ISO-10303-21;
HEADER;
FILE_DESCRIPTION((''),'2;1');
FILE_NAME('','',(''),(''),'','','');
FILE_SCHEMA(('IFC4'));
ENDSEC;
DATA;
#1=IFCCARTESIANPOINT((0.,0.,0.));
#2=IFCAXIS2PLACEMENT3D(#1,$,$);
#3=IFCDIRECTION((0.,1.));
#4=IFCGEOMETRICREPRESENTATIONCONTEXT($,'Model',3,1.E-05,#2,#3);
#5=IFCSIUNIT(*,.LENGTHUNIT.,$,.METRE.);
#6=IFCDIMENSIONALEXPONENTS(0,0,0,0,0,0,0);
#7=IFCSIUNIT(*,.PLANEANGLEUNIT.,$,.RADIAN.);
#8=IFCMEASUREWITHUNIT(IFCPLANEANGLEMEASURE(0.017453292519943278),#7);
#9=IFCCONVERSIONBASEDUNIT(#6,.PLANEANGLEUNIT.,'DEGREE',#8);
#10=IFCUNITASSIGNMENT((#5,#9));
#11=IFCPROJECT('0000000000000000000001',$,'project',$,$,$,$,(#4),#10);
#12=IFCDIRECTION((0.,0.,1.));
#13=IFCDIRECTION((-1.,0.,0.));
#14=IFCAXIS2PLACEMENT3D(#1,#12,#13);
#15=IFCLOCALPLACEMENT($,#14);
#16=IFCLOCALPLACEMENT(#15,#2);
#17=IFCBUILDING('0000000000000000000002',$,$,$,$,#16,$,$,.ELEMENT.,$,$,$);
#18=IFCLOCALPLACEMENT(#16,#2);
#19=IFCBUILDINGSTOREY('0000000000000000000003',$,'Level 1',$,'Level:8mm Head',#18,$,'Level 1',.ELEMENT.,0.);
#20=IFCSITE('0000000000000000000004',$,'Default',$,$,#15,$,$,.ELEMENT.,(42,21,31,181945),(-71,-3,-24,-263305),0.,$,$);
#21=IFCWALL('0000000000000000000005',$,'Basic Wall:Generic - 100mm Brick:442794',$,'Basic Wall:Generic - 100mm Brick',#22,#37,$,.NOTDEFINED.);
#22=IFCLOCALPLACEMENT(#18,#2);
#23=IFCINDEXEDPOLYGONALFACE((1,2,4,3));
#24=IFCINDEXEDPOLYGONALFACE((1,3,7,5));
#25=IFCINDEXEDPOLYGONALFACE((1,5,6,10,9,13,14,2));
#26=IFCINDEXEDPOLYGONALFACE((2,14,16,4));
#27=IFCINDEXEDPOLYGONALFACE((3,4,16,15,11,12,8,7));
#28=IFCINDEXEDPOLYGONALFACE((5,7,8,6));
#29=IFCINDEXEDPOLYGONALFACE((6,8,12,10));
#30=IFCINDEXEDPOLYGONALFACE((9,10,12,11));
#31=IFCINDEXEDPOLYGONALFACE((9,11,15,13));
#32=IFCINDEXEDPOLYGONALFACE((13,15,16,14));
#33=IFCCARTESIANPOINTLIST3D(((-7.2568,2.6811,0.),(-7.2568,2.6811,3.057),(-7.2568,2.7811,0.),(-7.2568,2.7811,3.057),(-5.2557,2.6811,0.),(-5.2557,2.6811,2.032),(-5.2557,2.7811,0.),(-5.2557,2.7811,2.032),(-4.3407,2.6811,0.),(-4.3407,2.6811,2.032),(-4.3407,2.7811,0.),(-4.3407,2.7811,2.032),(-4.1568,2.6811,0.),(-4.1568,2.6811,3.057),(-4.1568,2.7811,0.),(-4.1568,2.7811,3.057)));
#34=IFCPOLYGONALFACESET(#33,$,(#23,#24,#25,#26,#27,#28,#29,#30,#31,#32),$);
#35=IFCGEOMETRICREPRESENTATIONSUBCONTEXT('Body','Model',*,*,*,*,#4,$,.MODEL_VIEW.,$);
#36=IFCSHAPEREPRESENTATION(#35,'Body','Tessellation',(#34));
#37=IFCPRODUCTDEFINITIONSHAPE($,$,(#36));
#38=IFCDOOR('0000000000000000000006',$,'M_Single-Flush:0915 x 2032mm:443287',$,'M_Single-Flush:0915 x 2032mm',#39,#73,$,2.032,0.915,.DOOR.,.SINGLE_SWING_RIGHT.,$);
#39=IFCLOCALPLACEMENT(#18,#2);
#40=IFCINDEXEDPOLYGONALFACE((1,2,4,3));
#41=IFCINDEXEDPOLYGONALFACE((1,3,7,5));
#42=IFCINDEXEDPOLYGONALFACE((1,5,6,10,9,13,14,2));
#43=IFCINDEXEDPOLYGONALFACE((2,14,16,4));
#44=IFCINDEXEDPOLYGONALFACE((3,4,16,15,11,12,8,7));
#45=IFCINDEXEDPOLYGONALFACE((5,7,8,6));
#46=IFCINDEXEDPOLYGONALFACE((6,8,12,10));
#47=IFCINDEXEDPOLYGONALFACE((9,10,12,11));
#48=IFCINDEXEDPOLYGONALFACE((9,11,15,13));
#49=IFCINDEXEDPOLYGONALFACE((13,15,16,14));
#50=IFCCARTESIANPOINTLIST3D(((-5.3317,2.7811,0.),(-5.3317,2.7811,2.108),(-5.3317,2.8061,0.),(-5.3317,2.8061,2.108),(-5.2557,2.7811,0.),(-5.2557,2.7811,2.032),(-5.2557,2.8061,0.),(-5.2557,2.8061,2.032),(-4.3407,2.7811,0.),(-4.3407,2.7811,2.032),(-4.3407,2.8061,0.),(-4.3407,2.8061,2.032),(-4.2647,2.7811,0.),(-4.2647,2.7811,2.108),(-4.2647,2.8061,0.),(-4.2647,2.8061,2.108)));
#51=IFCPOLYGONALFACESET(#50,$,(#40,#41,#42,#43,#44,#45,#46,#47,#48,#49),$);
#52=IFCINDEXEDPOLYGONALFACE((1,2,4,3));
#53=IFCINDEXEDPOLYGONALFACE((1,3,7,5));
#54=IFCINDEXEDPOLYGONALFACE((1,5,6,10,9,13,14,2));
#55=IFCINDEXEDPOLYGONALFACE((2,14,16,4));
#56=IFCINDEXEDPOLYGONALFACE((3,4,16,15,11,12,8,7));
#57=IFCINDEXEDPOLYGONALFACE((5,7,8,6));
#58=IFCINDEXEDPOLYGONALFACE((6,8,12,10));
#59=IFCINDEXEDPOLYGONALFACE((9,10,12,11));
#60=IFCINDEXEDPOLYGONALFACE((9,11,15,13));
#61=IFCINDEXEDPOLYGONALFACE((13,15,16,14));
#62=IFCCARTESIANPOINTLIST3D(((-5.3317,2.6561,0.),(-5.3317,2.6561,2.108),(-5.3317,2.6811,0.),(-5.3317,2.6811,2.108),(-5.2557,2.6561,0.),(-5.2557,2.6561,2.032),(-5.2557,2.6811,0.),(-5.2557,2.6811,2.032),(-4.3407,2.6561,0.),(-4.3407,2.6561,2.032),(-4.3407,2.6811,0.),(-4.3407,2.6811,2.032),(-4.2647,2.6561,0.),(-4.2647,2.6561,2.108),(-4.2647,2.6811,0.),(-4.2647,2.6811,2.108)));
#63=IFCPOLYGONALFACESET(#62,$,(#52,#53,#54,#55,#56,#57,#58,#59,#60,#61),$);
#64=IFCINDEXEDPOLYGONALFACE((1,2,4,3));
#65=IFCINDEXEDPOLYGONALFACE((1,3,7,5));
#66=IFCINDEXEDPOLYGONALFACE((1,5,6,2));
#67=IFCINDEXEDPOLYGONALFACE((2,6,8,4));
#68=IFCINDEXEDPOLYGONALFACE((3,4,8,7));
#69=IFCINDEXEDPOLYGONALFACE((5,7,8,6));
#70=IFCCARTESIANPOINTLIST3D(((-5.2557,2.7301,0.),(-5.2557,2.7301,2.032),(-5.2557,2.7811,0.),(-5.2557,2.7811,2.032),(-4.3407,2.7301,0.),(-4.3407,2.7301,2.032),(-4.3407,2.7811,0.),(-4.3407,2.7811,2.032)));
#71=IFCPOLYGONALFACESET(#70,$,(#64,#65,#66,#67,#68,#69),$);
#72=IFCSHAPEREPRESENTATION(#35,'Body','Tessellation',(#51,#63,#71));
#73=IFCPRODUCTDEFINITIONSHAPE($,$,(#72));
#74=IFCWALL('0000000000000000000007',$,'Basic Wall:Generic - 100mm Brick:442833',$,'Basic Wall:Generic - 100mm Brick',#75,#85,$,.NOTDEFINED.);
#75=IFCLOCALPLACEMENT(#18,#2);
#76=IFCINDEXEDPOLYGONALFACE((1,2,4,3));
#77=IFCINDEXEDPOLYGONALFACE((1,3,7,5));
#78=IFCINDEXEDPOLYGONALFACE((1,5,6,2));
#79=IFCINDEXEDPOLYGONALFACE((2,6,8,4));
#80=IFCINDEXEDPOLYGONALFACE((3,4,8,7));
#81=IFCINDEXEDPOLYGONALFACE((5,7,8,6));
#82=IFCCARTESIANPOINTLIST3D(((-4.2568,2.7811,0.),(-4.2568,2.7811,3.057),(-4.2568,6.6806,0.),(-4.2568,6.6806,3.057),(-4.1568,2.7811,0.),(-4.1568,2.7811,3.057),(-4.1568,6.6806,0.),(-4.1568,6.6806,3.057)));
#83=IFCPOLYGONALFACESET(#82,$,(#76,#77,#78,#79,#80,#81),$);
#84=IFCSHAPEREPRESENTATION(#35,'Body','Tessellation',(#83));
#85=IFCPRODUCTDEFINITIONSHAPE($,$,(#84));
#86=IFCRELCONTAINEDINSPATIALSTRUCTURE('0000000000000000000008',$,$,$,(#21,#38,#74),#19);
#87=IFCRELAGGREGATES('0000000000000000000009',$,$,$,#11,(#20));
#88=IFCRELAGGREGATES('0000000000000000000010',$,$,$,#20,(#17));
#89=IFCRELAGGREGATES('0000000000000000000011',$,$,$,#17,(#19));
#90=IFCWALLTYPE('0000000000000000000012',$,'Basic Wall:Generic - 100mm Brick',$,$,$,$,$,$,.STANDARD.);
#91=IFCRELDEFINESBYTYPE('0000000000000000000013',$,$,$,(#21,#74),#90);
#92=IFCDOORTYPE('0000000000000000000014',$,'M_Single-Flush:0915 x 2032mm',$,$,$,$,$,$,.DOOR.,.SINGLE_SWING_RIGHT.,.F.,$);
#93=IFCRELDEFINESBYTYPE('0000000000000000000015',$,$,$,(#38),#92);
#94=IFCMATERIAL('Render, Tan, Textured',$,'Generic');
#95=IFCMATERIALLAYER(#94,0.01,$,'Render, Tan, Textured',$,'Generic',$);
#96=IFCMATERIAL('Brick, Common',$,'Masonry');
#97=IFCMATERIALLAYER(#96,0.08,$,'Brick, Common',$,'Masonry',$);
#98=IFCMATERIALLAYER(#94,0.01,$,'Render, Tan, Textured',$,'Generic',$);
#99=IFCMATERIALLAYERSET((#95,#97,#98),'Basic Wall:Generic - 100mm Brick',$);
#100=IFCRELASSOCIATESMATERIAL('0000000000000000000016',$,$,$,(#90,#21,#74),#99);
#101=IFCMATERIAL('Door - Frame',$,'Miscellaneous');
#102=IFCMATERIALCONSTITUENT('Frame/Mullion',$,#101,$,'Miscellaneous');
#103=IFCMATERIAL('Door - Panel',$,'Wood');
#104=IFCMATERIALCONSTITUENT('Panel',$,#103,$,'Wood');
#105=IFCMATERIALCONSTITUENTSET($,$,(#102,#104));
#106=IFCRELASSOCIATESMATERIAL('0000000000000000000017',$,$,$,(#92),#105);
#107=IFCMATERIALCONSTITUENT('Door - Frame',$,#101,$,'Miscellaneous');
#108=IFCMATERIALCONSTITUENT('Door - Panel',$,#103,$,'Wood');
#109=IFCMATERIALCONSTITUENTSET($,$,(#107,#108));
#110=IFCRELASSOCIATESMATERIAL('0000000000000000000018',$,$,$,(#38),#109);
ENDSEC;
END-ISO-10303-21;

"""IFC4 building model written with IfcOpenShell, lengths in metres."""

from ifc_helpers import new_model, entity, si_unit, converted_unit, direction, frame, frame_2d, origin, place, context, subcontext, project, spatial, polyline, rectangle, outline, extrude, source, transform, mapped, material, layer, layer_set, layer_usage, constituent, constituent_set, type_object, type_shapes, element, fill, save


model = new_model("IFC4")

# Units and contexts
model_context = context("Model", 3, precision=1e-05, world=origin(), true_north=direction((0.0, 1.0)))
body_context = subcontext(model_context, "Body", "Model", "MODEL_VIEW")
ifc_project = project(units=[si_unit("LENGTHUNIT", "METRE"), converted_unit("PLANEANGLEUNIT", "DEGREE", entity("IfcPlaneAngleMeasure", 0.017453292519943278), si_unit("PLANEANGLEUNIT", "RADIAN"), dimensions=[0, 0, 0, 0, 0, 0, 0])], contexts=[model_context])

# Site, building, storey
site_placement = place(None, frame((0.0, 0.0, 0.0), z_axis=(0.0, 0.0, 1.0), x_axis=(-1.0, 0.0, 0.0)))
site = spatial("IfcSite", under=ifc_project, at=site_placement, Name="Default", CompositionType="ELEMENT", RefLatitude=(42, 21, 31, 181945), RefLongitude=(-71, -3, -24, -263305), RefElevation=0.0)
building_placement = place(site_placement, origin())
building = spatial("IfcBuilding", under=site, at=building_placement, CompositionType="ELEMENT")
storey_placement = place(building_placement, origin())
storey = spatial("IfcBuildingStorey", under=building, at=storey_placement, Name="Level 1", ObjectType="Level:8mm Head", LongName="Level 1", CompositionType="ELEMENT", Elevation=0.0)

# Shared definitions
ifc_material_1 = material(Name="Brick, Common", Category="Masonry")

# Wall, opening, door
ifc_material_2 = material(Name="Render, Tan, Textured", Category="Generic")
ifc_layer_1 = layer(ifc_material_2, 0.01, Name="Render, Tan, Textured", Category="Generic")
ifc_layer_2 = layer(ifc_material_1, 0.08, Name="Brick, Common", Category="Masonry")
ifc_layer_3 = layer(ifc_material_2, 0.01, Name="Render, Tan, Textured", Category="Generic")
ifc_layer_set_1 = layer_set([ifc_layer_1, ifc_layer_2, ifc_layer_3], Name="Basic Wall:Generic - 100mm Brick")
ifc_layer_usage_1 = layer_usage(ifc_layer_set_1, "AXIS2", "NEGATIVE", 0.05)
wall_type_1 = type_object("IfcWallType", Name="Basic Wall:Generic - 100mm Brick", PredefinedType="STANDARD", material=ifc_layer_set_1)
wall_1_placement = place(storey_placement, frame((-7.2568, 2.7311, 0.0)))
wall_1 = element("IfcWall", 1, at=wall_1_placement, inside=storey, type_object=wall_type_1, material=ifc_layer_usage_1, Name="Basic Wall:Generic - 100mm Brick:442794", ObjectType="Basic Wall:Generic - 100mm Brick", PredefinedType="NOTDEFINED", context=body_context, shape_type="SweptSolid", body=[
    extrude(rectangle(XDim=3.1, YDim=0.1, at=frame_2d((1.55, 0.0), x_axis=(-1.0, 0.0))), origin(), (0.0, 0.0, 1.0), 3.057),
])
opening_1_placement = place(wall_1_placement, frame((2.0011, -0.05, 0.0)))
opening_1 = element("IfcOpeningElement", 2, at=opening_1_placement, cuts=wall_1, PredefinedType="OPENING", context=body_context, shape_type="SweptSolid", body=[
    extrude(rectangle(XDim=0.915, YDim=2.032, at=frame_2d((1.016, 0.4575), x_axis=(0.0, 1.0))), frame((0.0, 0.0, 0.0), z_axis=(0.0, 1.0, 0.0), x_axis=(0.0, 0.0, 1.0)), (0.0, 0.0, 1.0), 0.1),
])
ifc_material_3 = material(Name="Door - Frame", Category="Miscellaneous")
ifc_constituent_1 = constituent(ifc_material_3, Name="Door - Frame", Category="Miscellaneous")
ifc_material_4 = material(Name="Door - Panel", Category="Wood")
ifc_constituent_2 = constituent(ifc_material_4, Name="Door - Panel", Category="Wood")
ifc_constituent_set_1 = constituent_set(constituents=[ifc_constituent_1, ifc_constituent_2])
ifc_constituent_3 = constituent(ifc_material_3, Name="Frame/Mullion", Category="Miscellaneous")
ifc_constituent_4 = constituent(ifc_material_4, Name="Panel", Category="Wood")
ifc_constituent_set_2 = constituent_set(constituents=[ifc_constituent_3, ifc_constituent_4])
door_type_1 = type_object("IfcDoorType", Name="M_Single-Flush:0915 x 2032mm", OperationType="SINGLE_SWING_RIGHT", ParameterTakesPrecedence=False, PredefinedType="DOOR", material=ifc_constituent_set_2)
shared_shape_1 = source(origin(), body_context, "Body", "SweptSolid", [
    extrude(outline(polyline([(-0.5335, -1.073), (0.5335, -1.073), (0.5335, 1.035), (0.4575, 1.035), (0.4575, -0.997), (-0.4575, -0.997), (-0.4575, 1.035), (-0.5335, 1.035), (-0.5335, -1.073)])), frame((0.4575, 0.1, 1.035), z_axis=(0.0, 1.0, 0.0), x_axis=(1.0, 0.0, 0.0)), (0.0, 0.0, 1.0), 0.025),
    extrude(outline(polyline([(-1.073, -0.5335), (1.035, -0.5335), (1.035, -0.4575), (-0.997, -0.4575), (-0.997, 0.4575), (1.035, 0.4575), (1.035, 0.5335), (-1.073, 0.5335), (-1.073, -0.5335)])), frame((0.4575, -0.025, 1.035), z_axis=(0.0, 1.0, 0.0), x_axis=(0.0, 0.0, -1.0)), (0.0, 0.0, 1.0), 0.025),
    extrude(rectangle(XDim=0.051, YDim=0.915, at=frame_2d((0.0, 0.0), x_axis=(1.0, 0.0))), frame((0.4575, 0.0745, 0.0), z_axis=(0.0, 0.0, 1.0), x_axis=(0.0, 1.0, 0.0)), (0.0, 0.0, 1.0), 2.032),
])
type_shapes(door_type_1, [shared_shape_1])
door_1_placement = place(opening_1_placement, origin())
door_1 = element("IfcDoor", 3, at=door_1_placement, inside=storey, type_object=door_type_1, material=ifc_constituent_set_1, Name="M_Single-Flush:0915 x 2032mm:443287", ObjectType="M_Single-Flush:0915 x 2032mm", OperationType="SINGLE_SWING_RIGHT", OverallHeight=2.032, OverallWidth=0.915, PredefinedType="DOOR", context=body_context, shape_type="MappedRepresentation", body=[
    mapped(shared_shape_1, transform((0.0, 0.0, 0.0), scale=1.0)),
])
fill(opening_1, door_1)

# Wall
wall_2_placement = place(storey_placement, frame((-4.2068, 2.7811, 0.0), z_axis=(0.0, 0.0, 1.0), x_axis=(0.0, 1.0, 0.0)))
element("IfcWall", 4, at=wall_2_placement, inside=storey, type_object=wall_type_1, material=ifc_layer_usage_1, Name="Basic Wall:Generic - 100mm Brick:442833", ObjectType="Basic Wall:Generic - 100mm Brick", PredefinedType="NOTDEFINED", context=body_context, shape_type="SweptSolid", body=[
    extrude(rectangle(XDim=3.8995, YDim=0.1, at=frame_2d((1.9498, 0.0), x_axis=(-1.0, 0.0))), origin(), (0.0, 0.0, 1.0), 3.057),
])

save(model, "model.ifc")
